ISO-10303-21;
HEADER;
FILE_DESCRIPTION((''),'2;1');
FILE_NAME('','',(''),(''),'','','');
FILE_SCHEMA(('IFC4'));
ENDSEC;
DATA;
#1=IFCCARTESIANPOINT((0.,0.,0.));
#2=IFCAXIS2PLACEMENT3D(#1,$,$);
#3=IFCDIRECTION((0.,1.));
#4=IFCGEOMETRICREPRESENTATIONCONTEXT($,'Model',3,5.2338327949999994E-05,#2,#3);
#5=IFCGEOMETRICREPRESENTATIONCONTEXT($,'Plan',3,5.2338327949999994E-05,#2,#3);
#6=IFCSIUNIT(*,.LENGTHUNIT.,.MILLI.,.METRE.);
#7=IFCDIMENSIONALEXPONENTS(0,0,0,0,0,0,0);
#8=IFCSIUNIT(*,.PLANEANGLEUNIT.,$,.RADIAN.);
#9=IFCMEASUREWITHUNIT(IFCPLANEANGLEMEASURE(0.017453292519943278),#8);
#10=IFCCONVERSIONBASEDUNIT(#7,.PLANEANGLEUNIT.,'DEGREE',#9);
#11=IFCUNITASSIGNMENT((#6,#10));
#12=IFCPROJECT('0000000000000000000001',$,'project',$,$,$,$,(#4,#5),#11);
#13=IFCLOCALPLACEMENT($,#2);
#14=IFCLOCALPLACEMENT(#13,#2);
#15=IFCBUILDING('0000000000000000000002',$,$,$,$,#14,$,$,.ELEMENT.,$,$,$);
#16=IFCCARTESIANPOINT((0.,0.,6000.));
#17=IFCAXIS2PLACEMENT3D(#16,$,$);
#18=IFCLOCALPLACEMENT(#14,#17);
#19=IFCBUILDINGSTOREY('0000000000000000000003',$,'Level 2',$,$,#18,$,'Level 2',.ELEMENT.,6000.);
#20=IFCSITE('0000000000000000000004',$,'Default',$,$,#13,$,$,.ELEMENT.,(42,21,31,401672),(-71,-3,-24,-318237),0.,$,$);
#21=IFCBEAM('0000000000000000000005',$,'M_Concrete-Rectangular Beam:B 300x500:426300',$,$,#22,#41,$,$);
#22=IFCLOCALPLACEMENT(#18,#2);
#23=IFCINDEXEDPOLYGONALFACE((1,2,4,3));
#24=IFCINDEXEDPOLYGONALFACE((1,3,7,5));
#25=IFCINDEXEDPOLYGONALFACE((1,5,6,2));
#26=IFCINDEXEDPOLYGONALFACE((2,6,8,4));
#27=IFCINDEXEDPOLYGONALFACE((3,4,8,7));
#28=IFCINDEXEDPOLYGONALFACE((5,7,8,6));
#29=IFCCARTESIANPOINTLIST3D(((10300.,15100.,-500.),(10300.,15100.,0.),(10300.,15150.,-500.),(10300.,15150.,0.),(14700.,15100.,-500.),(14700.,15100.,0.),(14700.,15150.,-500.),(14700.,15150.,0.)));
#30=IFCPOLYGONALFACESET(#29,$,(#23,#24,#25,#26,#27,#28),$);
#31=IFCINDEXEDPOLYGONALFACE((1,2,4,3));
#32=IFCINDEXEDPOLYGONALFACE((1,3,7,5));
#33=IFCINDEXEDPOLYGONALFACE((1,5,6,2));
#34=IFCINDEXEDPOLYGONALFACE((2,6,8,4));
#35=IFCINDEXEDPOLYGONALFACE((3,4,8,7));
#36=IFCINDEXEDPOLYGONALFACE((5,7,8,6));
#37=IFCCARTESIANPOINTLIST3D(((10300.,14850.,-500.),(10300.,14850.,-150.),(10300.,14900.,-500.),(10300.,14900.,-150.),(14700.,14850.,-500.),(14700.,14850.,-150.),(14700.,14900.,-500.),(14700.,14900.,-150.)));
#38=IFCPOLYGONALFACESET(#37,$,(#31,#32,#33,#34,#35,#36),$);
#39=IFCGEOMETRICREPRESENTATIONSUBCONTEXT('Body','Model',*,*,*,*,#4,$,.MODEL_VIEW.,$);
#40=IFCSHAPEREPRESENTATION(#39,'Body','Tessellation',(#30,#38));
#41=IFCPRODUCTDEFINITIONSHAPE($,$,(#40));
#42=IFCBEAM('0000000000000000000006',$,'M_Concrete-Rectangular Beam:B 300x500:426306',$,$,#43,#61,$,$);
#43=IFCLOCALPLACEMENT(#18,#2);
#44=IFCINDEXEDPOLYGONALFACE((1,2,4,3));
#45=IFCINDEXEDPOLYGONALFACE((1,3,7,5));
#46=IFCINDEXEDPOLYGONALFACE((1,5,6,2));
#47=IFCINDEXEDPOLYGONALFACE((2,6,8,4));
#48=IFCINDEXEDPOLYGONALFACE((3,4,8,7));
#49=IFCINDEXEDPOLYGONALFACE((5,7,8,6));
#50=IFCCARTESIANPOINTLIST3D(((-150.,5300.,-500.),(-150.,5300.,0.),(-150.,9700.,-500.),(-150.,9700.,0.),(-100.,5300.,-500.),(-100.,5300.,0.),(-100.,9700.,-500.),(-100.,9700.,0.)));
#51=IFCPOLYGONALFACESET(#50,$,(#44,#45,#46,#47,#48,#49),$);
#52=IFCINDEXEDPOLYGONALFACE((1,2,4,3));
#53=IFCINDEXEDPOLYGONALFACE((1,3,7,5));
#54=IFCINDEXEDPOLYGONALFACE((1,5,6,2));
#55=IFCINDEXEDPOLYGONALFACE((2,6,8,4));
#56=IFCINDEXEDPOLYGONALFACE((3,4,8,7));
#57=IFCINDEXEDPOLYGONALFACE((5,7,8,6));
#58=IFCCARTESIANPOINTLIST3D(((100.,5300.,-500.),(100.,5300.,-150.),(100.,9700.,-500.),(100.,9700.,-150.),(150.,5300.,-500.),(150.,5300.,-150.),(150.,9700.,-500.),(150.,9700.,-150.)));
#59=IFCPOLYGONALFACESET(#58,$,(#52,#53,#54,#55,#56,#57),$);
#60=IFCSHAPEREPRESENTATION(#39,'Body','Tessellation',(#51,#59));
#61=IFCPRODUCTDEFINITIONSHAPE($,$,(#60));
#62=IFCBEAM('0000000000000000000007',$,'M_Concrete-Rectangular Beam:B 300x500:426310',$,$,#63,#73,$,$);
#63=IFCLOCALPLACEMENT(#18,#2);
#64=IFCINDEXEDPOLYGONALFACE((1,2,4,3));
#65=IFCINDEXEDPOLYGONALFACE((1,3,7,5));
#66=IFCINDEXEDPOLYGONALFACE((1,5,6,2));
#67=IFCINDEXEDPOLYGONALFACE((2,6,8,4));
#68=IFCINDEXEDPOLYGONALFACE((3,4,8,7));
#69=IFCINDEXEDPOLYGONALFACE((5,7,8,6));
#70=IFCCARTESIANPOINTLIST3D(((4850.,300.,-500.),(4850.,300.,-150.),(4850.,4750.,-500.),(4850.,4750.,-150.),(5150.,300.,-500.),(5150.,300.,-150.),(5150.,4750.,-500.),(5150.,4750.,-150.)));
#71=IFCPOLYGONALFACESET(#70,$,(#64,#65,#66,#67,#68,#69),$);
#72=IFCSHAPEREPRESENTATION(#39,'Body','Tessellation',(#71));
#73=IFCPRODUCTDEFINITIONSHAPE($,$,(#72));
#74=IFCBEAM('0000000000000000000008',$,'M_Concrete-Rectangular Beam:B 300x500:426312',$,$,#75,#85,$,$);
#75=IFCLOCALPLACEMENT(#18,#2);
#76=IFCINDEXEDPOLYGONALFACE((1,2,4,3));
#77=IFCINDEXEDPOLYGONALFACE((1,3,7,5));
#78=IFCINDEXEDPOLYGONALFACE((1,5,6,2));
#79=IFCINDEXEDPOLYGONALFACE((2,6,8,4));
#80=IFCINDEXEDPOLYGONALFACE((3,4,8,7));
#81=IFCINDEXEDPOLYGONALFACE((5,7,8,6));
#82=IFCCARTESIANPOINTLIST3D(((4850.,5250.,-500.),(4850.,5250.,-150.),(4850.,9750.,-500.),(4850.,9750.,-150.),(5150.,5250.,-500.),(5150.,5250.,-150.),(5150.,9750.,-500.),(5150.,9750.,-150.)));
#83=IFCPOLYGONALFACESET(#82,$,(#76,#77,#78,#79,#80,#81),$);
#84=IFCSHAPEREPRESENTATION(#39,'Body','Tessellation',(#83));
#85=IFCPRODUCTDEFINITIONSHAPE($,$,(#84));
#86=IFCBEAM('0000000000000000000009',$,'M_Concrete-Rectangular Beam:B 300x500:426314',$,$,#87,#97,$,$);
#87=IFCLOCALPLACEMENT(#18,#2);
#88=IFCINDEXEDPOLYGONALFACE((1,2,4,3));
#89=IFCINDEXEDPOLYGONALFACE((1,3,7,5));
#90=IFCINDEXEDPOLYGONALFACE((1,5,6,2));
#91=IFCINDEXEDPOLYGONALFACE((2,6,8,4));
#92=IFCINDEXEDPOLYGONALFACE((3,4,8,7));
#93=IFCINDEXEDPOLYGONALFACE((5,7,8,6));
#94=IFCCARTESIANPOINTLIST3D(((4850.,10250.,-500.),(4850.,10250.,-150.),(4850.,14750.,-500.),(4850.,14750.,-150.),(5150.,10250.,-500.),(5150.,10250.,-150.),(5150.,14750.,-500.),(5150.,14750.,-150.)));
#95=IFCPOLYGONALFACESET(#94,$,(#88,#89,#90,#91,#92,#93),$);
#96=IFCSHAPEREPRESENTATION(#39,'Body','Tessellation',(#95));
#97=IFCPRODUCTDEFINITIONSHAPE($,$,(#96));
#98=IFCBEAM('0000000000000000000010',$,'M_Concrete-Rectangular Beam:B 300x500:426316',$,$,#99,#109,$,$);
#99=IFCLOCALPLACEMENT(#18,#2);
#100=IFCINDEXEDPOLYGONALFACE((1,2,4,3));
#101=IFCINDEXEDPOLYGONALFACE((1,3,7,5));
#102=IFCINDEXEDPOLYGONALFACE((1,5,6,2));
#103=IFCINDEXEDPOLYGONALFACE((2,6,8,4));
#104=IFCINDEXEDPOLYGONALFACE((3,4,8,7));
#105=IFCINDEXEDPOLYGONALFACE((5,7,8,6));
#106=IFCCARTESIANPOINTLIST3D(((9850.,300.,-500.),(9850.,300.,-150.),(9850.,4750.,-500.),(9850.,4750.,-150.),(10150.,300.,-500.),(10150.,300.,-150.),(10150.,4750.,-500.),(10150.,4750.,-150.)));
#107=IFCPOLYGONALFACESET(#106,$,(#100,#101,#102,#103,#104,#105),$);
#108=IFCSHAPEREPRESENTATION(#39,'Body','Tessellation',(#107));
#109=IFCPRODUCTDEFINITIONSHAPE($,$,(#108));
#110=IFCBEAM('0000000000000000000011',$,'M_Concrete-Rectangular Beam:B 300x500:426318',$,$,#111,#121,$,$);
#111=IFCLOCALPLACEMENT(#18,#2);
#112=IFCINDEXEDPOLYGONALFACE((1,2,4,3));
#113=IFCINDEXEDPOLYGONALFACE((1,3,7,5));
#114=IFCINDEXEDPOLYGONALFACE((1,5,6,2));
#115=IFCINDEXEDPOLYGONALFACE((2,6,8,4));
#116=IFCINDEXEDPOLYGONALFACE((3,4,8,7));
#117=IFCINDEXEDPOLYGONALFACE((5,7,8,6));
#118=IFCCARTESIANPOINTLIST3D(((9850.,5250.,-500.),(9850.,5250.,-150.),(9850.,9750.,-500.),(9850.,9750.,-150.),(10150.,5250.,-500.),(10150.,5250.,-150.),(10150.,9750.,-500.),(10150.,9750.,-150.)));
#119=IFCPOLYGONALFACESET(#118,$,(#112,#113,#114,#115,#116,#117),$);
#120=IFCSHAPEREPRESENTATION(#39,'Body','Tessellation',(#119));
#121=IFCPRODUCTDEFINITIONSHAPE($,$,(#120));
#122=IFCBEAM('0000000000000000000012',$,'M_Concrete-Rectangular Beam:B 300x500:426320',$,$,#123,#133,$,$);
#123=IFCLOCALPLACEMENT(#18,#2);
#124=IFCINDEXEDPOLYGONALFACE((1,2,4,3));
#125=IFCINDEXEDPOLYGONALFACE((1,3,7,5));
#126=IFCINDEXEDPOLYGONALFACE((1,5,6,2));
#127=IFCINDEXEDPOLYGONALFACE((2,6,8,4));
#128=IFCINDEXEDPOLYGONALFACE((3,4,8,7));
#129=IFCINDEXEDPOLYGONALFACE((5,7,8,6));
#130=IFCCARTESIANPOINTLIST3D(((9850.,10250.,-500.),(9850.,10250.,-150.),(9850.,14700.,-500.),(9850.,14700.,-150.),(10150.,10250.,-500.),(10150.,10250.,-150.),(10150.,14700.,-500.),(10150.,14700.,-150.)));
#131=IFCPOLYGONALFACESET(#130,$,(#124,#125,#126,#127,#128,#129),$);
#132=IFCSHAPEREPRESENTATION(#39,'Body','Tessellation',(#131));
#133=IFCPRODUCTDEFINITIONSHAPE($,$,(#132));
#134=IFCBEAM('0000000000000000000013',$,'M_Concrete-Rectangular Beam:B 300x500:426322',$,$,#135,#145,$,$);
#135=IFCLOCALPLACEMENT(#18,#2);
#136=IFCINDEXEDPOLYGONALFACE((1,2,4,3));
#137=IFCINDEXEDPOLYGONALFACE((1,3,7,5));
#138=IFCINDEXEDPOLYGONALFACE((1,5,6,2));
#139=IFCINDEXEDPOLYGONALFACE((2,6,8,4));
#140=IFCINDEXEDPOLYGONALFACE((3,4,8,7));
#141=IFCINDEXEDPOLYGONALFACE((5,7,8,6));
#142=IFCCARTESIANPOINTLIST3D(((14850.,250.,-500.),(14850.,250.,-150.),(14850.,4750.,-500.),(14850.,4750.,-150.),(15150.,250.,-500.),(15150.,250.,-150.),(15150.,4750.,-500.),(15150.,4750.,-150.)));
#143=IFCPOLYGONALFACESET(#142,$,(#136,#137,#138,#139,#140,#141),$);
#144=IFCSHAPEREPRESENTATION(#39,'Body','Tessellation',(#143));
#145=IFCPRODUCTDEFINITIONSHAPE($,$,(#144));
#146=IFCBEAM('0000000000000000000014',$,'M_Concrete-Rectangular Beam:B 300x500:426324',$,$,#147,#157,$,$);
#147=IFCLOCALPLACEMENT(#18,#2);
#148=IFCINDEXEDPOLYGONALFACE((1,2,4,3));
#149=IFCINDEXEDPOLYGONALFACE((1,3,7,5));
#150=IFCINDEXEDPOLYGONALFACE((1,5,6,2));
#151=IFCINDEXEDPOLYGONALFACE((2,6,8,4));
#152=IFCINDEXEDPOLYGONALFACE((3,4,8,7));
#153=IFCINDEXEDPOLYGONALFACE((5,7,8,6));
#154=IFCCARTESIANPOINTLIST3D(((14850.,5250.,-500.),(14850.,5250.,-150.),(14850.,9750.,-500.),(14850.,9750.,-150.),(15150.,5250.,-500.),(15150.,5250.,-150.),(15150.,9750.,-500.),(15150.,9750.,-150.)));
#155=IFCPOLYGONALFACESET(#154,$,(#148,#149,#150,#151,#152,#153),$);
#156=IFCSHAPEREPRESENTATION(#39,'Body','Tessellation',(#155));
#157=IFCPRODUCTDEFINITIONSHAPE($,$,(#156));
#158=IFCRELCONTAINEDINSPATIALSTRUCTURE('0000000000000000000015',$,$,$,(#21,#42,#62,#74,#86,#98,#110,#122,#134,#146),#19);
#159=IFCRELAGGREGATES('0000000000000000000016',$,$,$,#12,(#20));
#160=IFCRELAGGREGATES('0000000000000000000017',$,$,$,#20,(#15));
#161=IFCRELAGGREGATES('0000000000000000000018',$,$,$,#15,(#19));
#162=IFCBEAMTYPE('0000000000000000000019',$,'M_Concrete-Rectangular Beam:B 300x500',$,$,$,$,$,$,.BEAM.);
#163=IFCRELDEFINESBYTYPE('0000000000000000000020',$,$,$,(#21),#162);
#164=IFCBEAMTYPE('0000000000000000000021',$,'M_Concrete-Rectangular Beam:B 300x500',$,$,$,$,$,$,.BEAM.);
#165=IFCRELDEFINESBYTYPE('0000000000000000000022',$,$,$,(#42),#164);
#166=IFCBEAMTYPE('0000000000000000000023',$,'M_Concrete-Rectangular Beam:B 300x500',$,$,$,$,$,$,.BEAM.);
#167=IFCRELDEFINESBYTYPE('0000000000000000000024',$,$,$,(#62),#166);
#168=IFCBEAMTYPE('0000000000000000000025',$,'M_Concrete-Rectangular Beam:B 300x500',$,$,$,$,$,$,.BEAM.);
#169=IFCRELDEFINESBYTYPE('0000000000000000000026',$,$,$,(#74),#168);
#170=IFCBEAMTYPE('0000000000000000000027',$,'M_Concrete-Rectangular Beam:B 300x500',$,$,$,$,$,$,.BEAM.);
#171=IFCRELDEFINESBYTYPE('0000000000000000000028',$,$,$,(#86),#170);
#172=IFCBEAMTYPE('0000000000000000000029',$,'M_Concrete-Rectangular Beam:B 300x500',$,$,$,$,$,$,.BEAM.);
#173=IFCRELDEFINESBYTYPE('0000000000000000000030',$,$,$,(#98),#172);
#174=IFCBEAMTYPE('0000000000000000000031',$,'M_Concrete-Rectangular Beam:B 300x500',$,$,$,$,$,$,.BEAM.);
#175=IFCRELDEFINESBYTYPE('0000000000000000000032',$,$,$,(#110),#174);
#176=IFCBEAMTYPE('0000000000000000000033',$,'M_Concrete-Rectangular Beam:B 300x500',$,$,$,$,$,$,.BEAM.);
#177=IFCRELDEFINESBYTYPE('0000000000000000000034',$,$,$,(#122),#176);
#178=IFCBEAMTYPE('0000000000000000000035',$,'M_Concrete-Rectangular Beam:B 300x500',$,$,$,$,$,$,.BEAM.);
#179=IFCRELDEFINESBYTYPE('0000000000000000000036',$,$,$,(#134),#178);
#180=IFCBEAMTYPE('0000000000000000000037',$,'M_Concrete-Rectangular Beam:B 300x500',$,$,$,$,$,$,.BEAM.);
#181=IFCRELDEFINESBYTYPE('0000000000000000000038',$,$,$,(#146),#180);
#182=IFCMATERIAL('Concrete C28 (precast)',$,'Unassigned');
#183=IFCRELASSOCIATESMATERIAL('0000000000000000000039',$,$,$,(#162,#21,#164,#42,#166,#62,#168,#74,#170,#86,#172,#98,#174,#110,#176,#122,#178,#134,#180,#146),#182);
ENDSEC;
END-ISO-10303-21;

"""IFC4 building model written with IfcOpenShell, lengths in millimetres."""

from ifc_helpers import new_model, entity, si_unit, converted_unit, direction, frame, origin, place, context, subcontext, project, spatial, indexed_curve, outline, extrude, source, transform, mapped, material, type_object, type_shapes, element, save


model = new_model("IFC4")

# Units and contexts
model_context = context("Model", 3, precision=5.2338327949999994e-05, world=origin(), true_north=direction((0.0, 1.0)))
plan_context = context("Plan", 3, precision=5.2338327949999994e-05, world=origin(), true_north=direction((0.0, 1.0)))
body_context = subcontext(model_context, "Body", "Model", "MODEL_VIEW")
ifc_project = project(units=[si_unit("LENGTHUNIT", "METRE", prefix="MILLI"), converted_unit("PLANEANGLEUNIT", "DEGREE", entity("IfcPlaneAngleMeasure", 0.017453292519943278), si_unit("PLANEANGLEUNIT", "RADIAN"), dimensions=[0, 0, 0, 0, 0, 0, 0])], contexts=[model_context, plan_context])

# Site, building, storey
site_placement = place(None, origin())
site = spatial("IfcSite", under=ifc_project, at=site_placement, Name="Default", CompositionType="ELEMENT", RefLatitude=(42, 21, 31, 401672), RefLongitude=(-71, -3, -24, -318237), RefElevation=0.0)
building_placement = place(site_placement, origin())
building = spatial("IfcBuilding", under=site, at=building_placement, CompositionType="ELEMENT")
storey_placement = place(building_placement, frame((0.0, 0.0, 6000.0)))
storey = spatial("IfcBuildingStorey", under=building, at=storey_placement, Name="Level 2", LongName="Level 2", CompositionType="ELEMENT", Elevation=6000.0)

# Beams
ifc_material = material(Name="Concrete C28 (precast)", Category="Unassigned")
beam_type_1 = type_object("IfcBeamType", Name="M_Concrete-Rectangular Beam:B 300x500", PredefinedType="BEAM", material=ifc_material)
shared_shape_1 = source(origin(), body_context, "Body", "SweptSolid", [
    extrude(outline(indexed_curve([(-250.0, -25.0), (250.0, -25.0), (250.0, 25.0), (-250.0, 25.0), (-250.0, -25.0)], self_intersect=False)), frame((10300.0, 15125.0, 5750.0), z_axis=(1.0, 0.0, 0.0), x_axis=(0.0, 0.0, -1.0)), (0.0, 0.0, 1.0), 4400.0),
    extrude(outline(indexed_curve([(-175.0, -25.0), (175.0, -25.0), (175.0, 25.0), (-175.0, 25.0), (-175.0, -25.0)], self_intersect=False)), frame((10300.0, 14875.0, 5675.0), z_axis=(1.0, 0.0, 0.0), x_axis=(0.0, 0.0, -1.0)), (0.0, 0.0, 1.0), 4400.0),
])
type_shapes(beam_type_1, [shared_shape_1])
beam_1_placement = place(storey_placement, frame((0.0, 0.0, -6000.0)))
element("IfcBeam", 1, at=beam_1_placement, inside=storey, type_object=beam_type_1, material=ifc_material, Name="M_Concrete-Rectangular Beam:B 300x500:426300", context=body_context, shape_type="MappedRepresentation", body=[
    mapped(shared_shape_1, transform((0.0, 0.0, 0.0), scale=1.0)),
])
beam_type_2 = type_object("IfcBeamType", Name="M_Concrete-Rectangular Beam:B 300x500", PredefinedType="BEAM", material=ifc_material)
shared_shape_2 = source(origin(), body_context, "Body", "SweptSolid", [
    extrude(outline(indexed_curve([(-25.0, -250.0), (25.0, -250.0), (25.0, 250.0), (-25.0, 250.0), (-25.0, -250.0)], self_intersect=False)), frame((-125.0, 5300.0, 5750.0), z_axis=(0.0, 1.0, 0.0), x_axis=(-1.0, 0.0, 0.0)), (0.0, 0.0, 1.0), 4400.0),
    extrude(outline(indexed_curve([(-25.0, -175.0), (25.0, -175.0), (25.0, 175.0), (-25.0, 175.0), (-25.0, -175.0)], self_intersect=False)), frame((125.0, 5300.0, 5675.0), z_axis=(0.0, 1.0, 0.0), x_axis=(-1.0, 0.0, 0.0)), (0.0, 0.0, 1.0), 4400.0),
])
type_shapes(beam_type_2, [shared_shape_2])
beam_2_placement = place(storey_placement, frame((0.0, 0.0, -6000.0)))
element("IfcBeam", 2, at=beam_2_placement, inside=storey, type_object=beam_type_2, material=ifc_material, Name="M_Concrete-Rectangular Beam:B 300x500:426306", context=body_context, shape_type="MappedRepresentation", body=[
    mapped(shared_shape_2, transform((0.0, 0.0, 0.0), scale=1.0)),
])
beam_type_3 = type_object("IfcBeamType", Name="M_Concrete-Rectangular Beam:B 300x500", PredefinedType="BEAM", material=ifc_material)
shared_shape_3 = source(origin(), body_context, "Body", "SweptSolid", [
    extrude(outline(indexed_curve([(-150.0, -175.0), (150.0, -175.0), (150.0, 175.0), (-150.0, 175.0), (-150.0, -175.0)], self_intersect=False)), frame((5000.0, 300.0, 5675.0), z_axis=(0.0, 1.0, 0.0), x_axis=(-1.0, 0.0, 0.0)), (0.0, 0.0, 1.0), 4450.0),
])
type_shapes(beam_type_3, [shared_shape_3])
beam_3_placement = place(storey_placement, frame((0.0, 0.0, -6000.0)))
element("IfcBeam", 3, at=beam_3_placement, inside=storey, type_object=beam_type_3, material=ifc_material, Name="M_Concrete-Rectangular Beam:B 300x500:426310", context=body_context, shape_type="MappedRepresentation", body=[
    mapped(shared_shape_3, transform((0.0, 0.0, 0.0), scale=1.0)),
])
beam_type_4 = type_object("IfcBeamType", Name="M_Concrete-Rectangular Beam:B 300x500", PredefinedType="BEAM", material=ifc_material)
shared_shape_4 = source(origin(), body_context, "Body", "SweptSolid", [
    extrude(outline(indexed_curve([(-150.0, -175.0), (150.0, -175.0), (150.0, 175.0), (-150.0, 175.0), (-150.0, -175.0)], self_intersect=False)), frame((5000.0, 5250.0, 5675.0), z_axis=(0.0, 1.0, 0.0), x_axis=(-1.0, 0.0, 0.0)), (0.0, 0.0, 1.0), 4500.0),
])
type_shapes(beam_type_4, [shared_shape_4])
beam_4_placement = place(storey_placement, frame((0.0, 0.0, -6000.0)))
element("IfcBeam", 4, at=beam_4_placement, inside=storey, type_object=beam_type_4, material=ifc_material, Name="M_Concrete-Rectangular Beam:B 300x500:426312", context=body_context, shape_type="MappedRepresentation", body=[
    mapped(shared_shape_4, transform((0.0, 0.0, 0.0), scale=1.0)),
])
beam_type_5 = type_object("IfcBeamType", Name="M_Concrete-Rectangular Beam:B 300x500", PredefinedType="BEAM", material=ifc_material)
shared_shape_5 = source(origin(), body_context, "Body", "SweptSolid", [
    extrude(outline(indexed_curve([(-150.0, -175.0), (150.0, -175.0), (150.0, 175.0), (-150.0, 175.0), (-150.0, -175.0)], self_intersect=False)), frame((5000.0, 10250.0, 5675.0), z_axis=(0.0, 1.0, 0.0), x_axis=(-1.0, 0.0, 0.0)), (0.0, 0.0, 1.0), 4500.0),
])
type_shapes(beam_type_5, [shared_shape_5])
beam_5_placement = place(storey_placement, frame((0.0, 0.0, -6000.0)))
element("IfcBeam", 5, at=beam_5_placement, inside=storey, type_object=beam_type_5, material=ifc_material, Name="M_Concrete-Rectangular Beam:B 300x500:426314", context=body_context, shape_type="MappedRepresentation", body=[
    mapped(shared_shape_5, transform((0.0, 0.0, 0.0), scale=1.0)),
])
beam_type_6 = type_object("IfcBeamType", Name="M_Concrete-Rectangular Beam:B 300x500", PredefinedType="BEAM", material=ifc_material)
shared_shape_6 = source(origin(), body_context, "Body", "SweptSolid", [
    extrude(outline(indexed_curve([(-150.0, -175.0), (150.0, -175.0), (150.0, 175.0), (-150.0, 175.0), (-150.0, -175.0)], self_intersect=False)), frame((10000.0, 300.0, 5675.0), z_axis=(0.0, 1.0, 0.0), x_axis=(-1.0, 0.0, 0.0)), (0.0, 0.0, 1.0), 4450.0),
])
type_shapes(beam_type_6, [shared_shape_6])
beam_6_placement = place(storey_placement, frame((0.0, 0.0, -6000.0)))
element("IfcBeam", 6, at=beam_6_placement, inside=storey, type_object=beam_type_6, material=ifc_material, Name="M_Concrete-Rectangular Beam:B 300x500:426316", context=body_context, shape_type="MappedRepresentation", body=[
    mapped(shared_shape_6, transform((0.0, 0.0, 0.0), scale=1.0)),
])
beam_type_7 = type_object("IfcBeamType", Name="M_Concrete-Rectangular Beam:B 300x500", PredefinedType="BEAM", material=ifc_material)
shared_shape_7 = source(origin(), body_context, "Body", "SweptSolid", [
    extrude(outline(indexed_curve([(-150.0, -175.0), (150.0, -175.0), (150.0, 175.0), (-150.0, 175.0), (-150.0, -175.0)], self_intersect=False)), frame((10000.0, 5250.0, 5675.0), z_axis=(0.0, 1.0, 0.0), x_axis=(-1.0, 0.0, 0.0)), (0.0, 0.0, 1.0), 4500.0),
])
type_shapes(beam_type_7, [shared_shape_7])
beam_7_placement = place(storey_placement, frame((0.0, 0.0, -6000.0)))
element("IfcBeam", 7, at=beam_7_placement, inside=storey, type_object=beam_type_7, material=ifc_material, Name="M_Concrete-Rectangular Beam:B 300x500:426318", context=body_context, shape_type="MappedRepresentation", body=[
    mapped(shared_shape_7, transform((0.0, 0.0, 0.0), scale=1.0)),
])
beam_type_8 = type_object("IfcBeamType", Name="M_Concrete-Rectangular Beam:B 300x500", PredefinedType="BEAM", material=ifc_material)
shared_shape_8 = source(origin(), body_context, "Body", "SweptSolid", [
    extrude(outline(indexed_curve([(-150.0, -175.0), (150.0, -175.0), (150.0, 175.0), (-150.0, 175.0), (-150.0, -175.0)], self_intersect=False)), frame((10000.0, 10250.0, 5675.0), z_axis=(0.0, 1.0, 0.0), x_axis=(-1.0, 0.0, 0.0)), (0.0, 0.0, 1.0), 4450.0),
])
type_shapes(beam_type_8, [shared_shape_8])
beam_8_placement = place(storey_placement, frame((0.0, 0.0, -6000.0)))
element("IfcBeam", 8, at=beam_8_placement, inside=storey, type_object=beam_type_8, material=ifc_material, Name="M_Concrete-Rectangular Beam:B 300x500:426320", context=body_context, shape_type="MappedRepresentation", body=[
    mapped(shared_shape_8, transform((0.0, 0.0, 0.0), scale=1.0)),
])
beam_type_9 = type_object("IfcBeamType", Name="M_Concrete-Rectangular Beam:B 300x500", PredefinedType="BEAM", material=ifc_material)
shared_shape_9 = source(origin(), body_context, "Body", "SweptSolid", [
    extrude(outline(indexed_curve([(-150.0, -175.0), (150.0, -175.0), (150.0, 175.0), (-150.0, 175.0), (-150.0, -175.0)], self_intersect=False)), frame((15000.0, 250.0, 5675.0), z_axis=(0.0, 1.0, 0.0), x_axis=(-1.0, 0.0, 0.0)), (0.0, 0.0, 1.0), 4500.0),
])
type_shapes(beam_type_9, [shared_shape_9])
beam_9_placement = place(storey_placement, frame((0.0, 0.0, -6000.0)))
element("IfcBeam", 9, at=beam_9_placement, inside=storey, type_object=beam_type_9, material=ifc_material, Name="M_Concrete-Rectangular Beam:B 300x500:426322", context=body_context, shape_type="MappedRepresentation", body=[
    mapped(shared_shape_9, transform((0.0, 0.0, 0.0), scale=1.0)),
])
beam_type_10 = type_object("IfcBeamType", Name="M_Concrete-Rectangular Beam:B 300x500", PredefinedType="BEAM", material=ifc_material)
shared_shape_10 = source(origin(), body_context, "Body", "SweptSolid", [
    extrude(outline(indexed_curve([(-150.0, -175.0), (150.0, -175.0), (150.0, 175.0), (-150.0, 175.0), (-150.0, -175.0)], self_intersect=False)), frame((15000.0, 5250.0, 5675.0), z_axis=(0.0, 1.0, 0.0), x_axis=(-1.0, 0.0, 0.0)), (0.0, 0.0, 1.0), 4500.0),
])
type_shapes(beam_type_10, [shared_shape_10])
beam_10_placement = place(storey_placement, frame((0.0, 0.0, -6000.0)))
element("IfcBeam", 10, at=beam_10_placement, inside=storey, type_object=beam_type_10, material=ifc_material, Name="M_Concrete-Rectangular Beam:B 300x500:426324", context=body_context, shape_type="MappedRepresentation", body=[
    mapped(shared_shape_10, transform((0.0, 0.0, 0.0), scale=1.0)),
])

save(model, "model.ifc")
